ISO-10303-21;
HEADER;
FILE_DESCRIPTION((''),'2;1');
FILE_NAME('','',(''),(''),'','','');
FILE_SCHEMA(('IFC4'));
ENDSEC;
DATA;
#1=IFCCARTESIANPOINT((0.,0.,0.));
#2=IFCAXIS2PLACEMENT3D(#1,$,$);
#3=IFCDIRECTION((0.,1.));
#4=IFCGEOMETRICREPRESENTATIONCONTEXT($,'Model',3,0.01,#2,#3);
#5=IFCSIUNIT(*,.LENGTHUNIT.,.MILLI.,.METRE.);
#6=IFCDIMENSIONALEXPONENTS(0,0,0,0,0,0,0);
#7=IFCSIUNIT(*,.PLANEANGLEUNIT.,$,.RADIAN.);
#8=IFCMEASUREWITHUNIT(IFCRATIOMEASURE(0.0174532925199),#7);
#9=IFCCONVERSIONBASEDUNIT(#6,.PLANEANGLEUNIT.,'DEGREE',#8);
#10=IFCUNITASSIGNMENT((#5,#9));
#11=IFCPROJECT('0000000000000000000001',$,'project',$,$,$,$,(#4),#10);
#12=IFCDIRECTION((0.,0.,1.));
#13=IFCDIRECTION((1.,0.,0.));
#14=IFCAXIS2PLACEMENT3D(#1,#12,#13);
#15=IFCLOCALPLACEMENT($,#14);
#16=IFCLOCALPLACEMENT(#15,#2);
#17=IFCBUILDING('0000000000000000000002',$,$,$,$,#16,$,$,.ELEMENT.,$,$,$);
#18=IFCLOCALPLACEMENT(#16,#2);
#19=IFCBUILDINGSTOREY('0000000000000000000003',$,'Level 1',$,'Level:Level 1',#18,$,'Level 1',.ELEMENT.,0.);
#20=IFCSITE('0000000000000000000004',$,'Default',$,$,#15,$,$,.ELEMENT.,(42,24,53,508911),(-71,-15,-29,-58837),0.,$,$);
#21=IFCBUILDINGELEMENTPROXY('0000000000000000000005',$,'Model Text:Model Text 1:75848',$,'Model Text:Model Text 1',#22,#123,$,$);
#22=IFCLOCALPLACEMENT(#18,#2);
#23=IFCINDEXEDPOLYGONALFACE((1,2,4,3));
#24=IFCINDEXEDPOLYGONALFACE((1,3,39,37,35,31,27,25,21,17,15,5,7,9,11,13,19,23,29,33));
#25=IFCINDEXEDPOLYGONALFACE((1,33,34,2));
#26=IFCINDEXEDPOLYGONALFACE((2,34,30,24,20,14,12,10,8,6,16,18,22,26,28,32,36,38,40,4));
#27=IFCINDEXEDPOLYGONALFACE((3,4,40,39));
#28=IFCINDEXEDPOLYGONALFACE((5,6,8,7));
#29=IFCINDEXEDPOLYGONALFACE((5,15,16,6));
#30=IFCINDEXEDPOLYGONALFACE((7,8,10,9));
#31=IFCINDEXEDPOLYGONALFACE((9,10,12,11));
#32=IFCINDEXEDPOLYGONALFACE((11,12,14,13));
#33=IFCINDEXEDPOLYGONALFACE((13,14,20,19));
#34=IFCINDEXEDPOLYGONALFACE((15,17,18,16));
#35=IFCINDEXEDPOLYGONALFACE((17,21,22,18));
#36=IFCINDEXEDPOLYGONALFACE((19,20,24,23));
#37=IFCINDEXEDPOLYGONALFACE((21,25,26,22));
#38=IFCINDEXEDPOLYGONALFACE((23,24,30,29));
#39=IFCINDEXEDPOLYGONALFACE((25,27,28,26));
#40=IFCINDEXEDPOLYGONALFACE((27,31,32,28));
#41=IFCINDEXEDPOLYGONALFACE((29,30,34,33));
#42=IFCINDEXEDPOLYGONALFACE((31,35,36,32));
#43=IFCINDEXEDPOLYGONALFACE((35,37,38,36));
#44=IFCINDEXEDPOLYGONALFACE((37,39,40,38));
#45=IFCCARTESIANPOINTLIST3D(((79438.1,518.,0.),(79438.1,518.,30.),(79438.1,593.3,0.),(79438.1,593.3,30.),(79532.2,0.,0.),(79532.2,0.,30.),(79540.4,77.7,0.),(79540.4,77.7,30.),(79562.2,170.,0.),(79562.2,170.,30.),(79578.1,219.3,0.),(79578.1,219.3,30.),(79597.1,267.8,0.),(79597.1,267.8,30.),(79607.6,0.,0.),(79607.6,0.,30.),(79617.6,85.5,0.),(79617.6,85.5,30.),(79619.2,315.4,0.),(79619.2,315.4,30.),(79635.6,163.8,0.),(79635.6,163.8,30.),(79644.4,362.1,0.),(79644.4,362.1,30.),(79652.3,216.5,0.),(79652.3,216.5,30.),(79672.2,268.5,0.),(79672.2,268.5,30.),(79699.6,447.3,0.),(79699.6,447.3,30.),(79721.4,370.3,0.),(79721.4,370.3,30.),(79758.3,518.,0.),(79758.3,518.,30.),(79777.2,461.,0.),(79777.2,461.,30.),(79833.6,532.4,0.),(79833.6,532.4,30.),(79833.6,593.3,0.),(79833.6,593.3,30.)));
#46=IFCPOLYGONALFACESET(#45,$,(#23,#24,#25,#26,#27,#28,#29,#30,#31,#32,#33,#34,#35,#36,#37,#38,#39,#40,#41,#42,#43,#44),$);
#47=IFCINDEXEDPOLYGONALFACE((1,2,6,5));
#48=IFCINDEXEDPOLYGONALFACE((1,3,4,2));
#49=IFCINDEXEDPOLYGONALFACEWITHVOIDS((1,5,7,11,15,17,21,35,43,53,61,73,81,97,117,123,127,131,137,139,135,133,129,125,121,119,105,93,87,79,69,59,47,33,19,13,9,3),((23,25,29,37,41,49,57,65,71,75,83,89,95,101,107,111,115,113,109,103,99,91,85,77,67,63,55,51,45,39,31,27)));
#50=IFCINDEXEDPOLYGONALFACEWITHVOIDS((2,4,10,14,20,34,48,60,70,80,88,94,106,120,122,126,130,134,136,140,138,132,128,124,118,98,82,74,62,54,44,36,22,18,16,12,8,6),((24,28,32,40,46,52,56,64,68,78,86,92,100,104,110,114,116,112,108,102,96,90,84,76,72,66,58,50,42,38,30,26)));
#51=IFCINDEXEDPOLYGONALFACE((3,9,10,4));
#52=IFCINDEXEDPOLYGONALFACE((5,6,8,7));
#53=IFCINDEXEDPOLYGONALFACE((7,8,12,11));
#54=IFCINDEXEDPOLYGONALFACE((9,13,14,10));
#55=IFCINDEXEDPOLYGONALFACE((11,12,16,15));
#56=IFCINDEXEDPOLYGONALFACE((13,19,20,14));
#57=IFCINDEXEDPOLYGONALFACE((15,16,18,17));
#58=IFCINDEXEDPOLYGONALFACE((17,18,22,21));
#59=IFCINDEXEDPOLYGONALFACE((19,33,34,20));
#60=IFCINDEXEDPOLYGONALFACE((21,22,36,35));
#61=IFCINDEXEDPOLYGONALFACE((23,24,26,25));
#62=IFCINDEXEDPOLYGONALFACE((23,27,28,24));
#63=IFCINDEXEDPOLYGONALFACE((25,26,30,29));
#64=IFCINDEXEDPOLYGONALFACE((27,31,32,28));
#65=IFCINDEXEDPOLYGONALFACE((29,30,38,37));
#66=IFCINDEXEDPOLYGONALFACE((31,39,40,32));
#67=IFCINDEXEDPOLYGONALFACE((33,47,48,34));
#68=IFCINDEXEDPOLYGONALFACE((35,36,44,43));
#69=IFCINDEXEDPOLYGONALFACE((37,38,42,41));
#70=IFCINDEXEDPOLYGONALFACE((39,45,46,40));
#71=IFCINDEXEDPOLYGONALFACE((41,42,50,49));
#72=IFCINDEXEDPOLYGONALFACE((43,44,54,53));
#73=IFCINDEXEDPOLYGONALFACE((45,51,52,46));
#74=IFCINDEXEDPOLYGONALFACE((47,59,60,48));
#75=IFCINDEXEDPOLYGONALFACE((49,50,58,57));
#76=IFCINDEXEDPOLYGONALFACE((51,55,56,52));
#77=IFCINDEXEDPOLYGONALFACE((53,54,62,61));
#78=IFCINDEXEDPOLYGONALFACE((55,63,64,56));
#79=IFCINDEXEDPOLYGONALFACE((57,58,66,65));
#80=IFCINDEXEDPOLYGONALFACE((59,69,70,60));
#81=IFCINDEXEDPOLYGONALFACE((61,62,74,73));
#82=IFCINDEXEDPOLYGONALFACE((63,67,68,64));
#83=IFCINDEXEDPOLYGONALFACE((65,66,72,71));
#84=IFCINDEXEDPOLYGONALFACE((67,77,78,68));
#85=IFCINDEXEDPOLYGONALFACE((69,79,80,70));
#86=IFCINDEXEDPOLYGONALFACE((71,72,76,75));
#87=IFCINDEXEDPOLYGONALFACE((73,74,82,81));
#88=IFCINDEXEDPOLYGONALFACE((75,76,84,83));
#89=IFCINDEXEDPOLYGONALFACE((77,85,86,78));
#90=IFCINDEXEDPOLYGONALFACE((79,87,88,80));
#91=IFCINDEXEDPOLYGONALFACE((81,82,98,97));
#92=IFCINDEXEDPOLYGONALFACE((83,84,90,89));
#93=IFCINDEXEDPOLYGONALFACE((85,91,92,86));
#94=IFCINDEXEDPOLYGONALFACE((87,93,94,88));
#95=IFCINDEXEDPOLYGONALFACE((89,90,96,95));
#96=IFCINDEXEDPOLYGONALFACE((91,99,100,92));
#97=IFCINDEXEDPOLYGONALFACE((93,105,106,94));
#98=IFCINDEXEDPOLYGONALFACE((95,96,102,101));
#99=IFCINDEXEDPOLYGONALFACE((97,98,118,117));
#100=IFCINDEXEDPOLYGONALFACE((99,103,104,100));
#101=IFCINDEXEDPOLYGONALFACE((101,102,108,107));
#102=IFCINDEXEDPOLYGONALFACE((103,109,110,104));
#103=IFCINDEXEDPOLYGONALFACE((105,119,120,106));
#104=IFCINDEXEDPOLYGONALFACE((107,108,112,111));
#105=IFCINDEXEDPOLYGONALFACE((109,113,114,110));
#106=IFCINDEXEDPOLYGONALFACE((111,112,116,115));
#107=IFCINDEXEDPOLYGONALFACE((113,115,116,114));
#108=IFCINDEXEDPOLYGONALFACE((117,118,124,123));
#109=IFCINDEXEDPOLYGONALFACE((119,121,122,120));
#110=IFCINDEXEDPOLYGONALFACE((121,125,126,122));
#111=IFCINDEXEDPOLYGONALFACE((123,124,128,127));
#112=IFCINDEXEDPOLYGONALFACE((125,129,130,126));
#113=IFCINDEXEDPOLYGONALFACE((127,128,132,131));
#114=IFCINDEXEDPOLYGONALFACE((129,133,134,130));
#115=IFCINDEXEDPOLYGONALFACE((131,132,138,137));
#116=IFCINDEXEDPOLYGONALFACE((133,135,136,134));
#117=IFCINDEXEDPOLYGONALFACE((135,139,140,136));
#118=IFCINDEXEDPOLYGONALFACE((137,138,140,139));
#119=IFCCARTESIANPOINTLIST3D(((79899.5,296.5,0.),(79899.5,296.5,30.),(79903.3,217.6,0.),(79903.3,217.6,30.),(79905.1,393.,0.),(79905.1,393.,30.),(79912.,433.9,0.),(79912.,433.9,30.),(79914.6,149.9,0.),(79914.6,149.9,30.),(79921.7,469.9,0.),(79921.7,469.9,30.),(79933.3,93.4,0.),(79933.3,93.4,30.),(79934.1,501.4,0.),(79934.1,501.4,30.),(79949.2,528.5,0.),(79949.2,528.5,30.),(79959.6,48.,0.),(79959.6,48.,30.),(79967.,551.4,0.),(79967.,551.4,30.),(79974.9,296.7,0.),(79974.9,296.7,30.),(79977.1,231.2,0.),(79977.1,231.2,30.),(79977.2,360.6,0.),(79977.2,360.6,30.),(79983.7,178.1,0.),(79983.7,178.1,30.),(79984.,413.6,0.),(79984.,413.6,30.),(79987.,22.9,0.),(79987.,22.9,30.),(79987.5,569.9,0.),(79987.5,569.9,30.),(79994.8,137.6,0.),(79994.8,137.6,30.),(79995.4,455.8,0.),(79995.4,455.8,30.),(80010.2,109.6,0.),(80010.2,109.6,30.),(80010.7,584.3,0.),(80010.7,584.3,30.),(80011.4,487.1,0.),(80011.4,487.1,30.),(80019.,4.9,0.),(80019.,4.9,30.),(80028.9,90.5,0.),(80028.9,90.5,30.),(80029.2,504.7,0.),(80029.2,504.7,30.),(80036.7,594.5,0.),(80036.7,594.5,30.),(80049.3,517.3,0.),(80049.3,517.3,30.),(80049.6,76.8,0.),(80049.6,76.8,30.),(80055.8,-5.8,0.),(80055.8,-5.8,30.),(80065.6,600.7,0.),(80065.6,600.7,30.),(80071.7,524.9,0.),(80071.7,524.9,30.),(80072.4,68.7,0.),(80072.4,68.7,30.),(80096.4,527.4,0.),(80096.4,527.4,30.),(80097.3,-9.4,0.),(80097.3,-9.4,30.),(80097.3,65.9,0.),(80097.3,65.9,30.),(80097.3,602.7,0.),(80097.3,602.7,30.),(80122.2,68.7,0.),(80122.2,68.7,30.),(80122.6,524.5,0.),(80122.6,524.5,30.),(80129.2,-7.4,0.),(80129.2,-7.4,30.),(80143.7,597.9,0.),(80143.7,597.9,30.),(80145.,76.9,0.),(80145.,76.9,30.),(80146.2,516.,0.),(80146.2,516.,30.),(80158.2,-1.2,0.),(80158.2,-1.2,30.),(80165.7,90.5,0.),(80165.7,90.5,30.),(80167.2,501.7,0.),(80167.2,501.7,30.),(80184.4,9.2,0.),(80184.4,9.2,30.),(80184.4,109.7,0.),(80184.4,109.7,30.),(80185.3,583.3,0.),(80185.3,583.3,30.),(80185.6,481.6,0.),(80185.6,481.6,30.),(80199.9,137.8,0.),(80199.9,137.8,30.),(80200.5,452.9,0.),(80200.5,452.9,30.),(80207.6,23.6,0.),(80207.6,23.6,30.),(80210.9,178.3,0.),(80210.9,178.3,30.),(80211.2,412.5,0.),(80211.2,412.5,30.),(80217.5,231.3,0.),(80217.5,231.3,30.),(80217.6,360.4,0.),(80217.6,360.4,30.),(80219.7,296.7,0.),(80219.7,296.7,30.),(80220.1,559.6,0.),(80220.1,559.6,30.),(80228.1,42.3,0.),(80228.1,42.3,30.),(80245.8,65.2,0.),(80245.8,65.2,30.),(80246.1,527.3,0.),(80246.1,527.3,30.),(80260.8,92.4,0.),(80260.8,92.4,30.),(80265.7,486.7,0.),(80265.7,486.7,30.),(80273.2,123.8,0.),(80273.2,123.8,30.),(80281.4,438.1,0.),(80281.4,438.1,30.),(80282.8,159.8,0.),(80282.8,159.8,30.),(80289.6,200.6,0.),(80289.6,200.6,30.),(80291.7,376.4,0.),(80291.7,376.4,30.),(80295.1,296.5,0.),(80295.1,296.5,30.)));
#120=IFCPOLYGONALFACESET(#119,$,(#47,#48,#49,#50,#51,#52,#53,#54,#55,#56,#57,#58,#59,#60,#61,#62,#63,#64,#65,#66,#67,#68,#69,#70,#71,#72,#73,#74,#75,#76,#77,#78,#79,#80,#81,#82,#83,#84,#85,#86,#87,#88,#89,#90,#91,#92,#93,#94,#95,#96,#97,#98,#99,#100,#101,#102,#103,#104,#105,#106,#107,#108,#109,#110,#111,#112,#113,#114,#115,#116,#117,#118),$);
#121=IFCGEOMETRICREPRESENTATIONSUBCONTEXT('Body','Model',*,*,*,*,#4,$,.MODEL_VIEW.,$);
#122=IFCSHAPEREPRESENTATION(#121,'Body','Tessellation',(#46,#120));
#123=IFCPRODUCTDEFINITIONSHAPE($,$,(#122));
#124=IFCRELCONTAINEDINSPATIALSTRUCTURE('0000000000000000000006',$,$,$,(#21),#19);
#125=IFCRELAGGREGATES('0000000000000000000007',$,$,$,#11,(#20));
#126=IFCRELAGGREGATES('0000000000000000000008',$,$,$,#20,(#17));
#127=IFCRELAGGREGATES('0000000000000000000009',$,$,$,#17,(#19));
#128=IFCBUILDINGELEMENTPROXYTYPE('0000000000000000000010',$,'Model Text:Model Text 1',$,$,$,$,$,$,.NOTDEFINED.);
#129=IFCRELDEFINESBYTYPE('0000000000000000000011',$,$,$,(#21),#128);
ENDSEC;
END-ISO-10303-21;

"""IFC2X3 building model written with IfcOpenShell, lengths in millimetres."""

from ifc_helpers import new_model, entity, si_unit, converted_unit, direction, frame, origin, origin_with_axes, place, context, subcontext, project, spatial, polyline, outline, extrude, type_object, element, save


model = new_model("IFC2X3")

# Units and contexts
model_context = context("Model", 3, precision=0.01, world=origin(), true_north=direction((0.0, 1.0)))
body_context = subcontext(model_context, "Body", "Model", "MODEL_VIEW")
ifc_project = project(units=[si_unit("LENGTHUNIT", "METRE", prefix="MILLI"), converted_unit("PLANEANGLEUNIT", "DEGREE", entity("IfcRatioMeasure", 0.0174532925199), si_unit("PLANEANGLEUNIT", "RADIAN"), dimensions=[0, 0, 0, 0, 0, 0, 0])], contexts=[model_context])

# Site, building, storey
site_placement = place(None, origin_with_axes())
site = spatial("IfcSite", under=ifc_project, at=site_placement, Name="Default", CompositionType="ELEMENT", RefLatitude=(42, 24, 53, 508911), RefLongitude=(-71, -15, -29, -58837), RefElevation=0.0)
building_placement = place(site_placement, origin())
building = spatial("IfcBuilding", under=site, at=building_placement, CompositionType="ELEMENT")
storey_placement = place(building_placement, origin())
storey = spatial("IfcBuildingStorey", under=building, at=storey_placement, Name="Level 1", ObjectType="Level:Level 1", LongName="Level 1", CompositionType="ELEMENT", Elevation=0.0)

# Building element proxy
building_element_proxy_type_1 = type_object("IfcBuildingElementProxyType", Name="Model Text:Model Text 1", PredefinedType="NOTDEFINED")
proxy_1_placement = place(storey_placement, frame((79438.1, -9.4, 0.0)))
element("IfcBuildingElementProxy", 1, at=proxy_1_placement, inside=storey, type_object=building_element_proxy_type_1, Name="Model Text:Model Text 1:75848", ObjectType="Model Text:Model Text 1", context=body_context, shape_type="SweptSolid", body=[
    extrude(outline(polyline([(-199.9, -209.0), (-199.9, -284.3), (195.7, -284.3), (195.7, -223.4), (139.3, -152.0), (83.5, -61.3), (34.2, 40.5), (14.4, 92.5), (-2.4, 145.2), (-20.3, 223.5), (-30.3, 309.0), (-105.7, 309.0), (-97.5, 231.3), (-75.7, 139.0), (-59.9, 89.7), (-40.9, 41.2), (-18.8, -6.4), (6.4, -53.1), (61.7, -138.3), (120.3, -209.0), (-199.9, -209.0)])), frame((199.9, 318.4, 0.0), z_axis=(0.0, 0.0, -1.0), x_axis=(1.0, 0.0, 0.0)), (0.0, 0.0, -1.0), 30.0),
    extrude(outline(polyline([(-10.6, -198.7), (68.3, -198.7), (136.5, -190.7), (193.9, -174.7), (240.5, -150.6), (266.9, -124.4), (286.3, -93.2), (298.8, -57.0), (304.3, -15.7), (303.8, 16.2), (299.0, 45.5), (289.9, 72.1), (276.6, 96.0), (258.9, 117.3), (236.9, 136.2), (210.4, 152.5), (179.6, 166.3), (144.1, 177.6), (103.7, 186.3), (8.2, 196.4), (-71.8, 196.7), (-134.0, 189.4), (-183.3, 176.1), (-224.7, 158.4), (-258.2, 133.9), (-283.5, 100.3), (-300.1, 59.5), (-307.1, 13.4), (-306.6, -18.4), (-301.8, -47.5), (-292.8, -74.0), (-279.6, -97.9), (-262.0, -119.2), (-240.0, -138.1), (-213.6, -154.5), (-182.8, -168.4), (-147.3, -179.8), (-106.7, -188.6), (-10.6, -198.7)]), holes=[polyline([(-7.2, -123.5), (-71.0, -118.2), (-123.6, -108.8), (-165.2, -95.4), (-195.7, -78.0), (-212.4, -59.4), (-224.1, -38.7), (-230.6, -15.9), (-231.9, 8.9), (-227.8, 35.0), (-218.1, 58.1), (-202.8, 78.4), (-182.0, 95.8), (-152.6, 109.4), (-111.7, 118.1), (-59.4, 122.0), (4.4, 121.1), (69.6, 115.8), (122.2, 106.7), (162.2, 93.7), (189.5, 77.0), (207.7, 57.4), (220.4, 36.0), (227.5, 12.8), (229.1, -12.1), (225.2, -36.8), (215.9, -59.2), (201.3, -79.3), (181.4, -97.1), (152.6, -111.2), (111.6, -120.3), (58.3, -124.4), (-7.2, -123.5)])]), frame((660.5, 304.7, 0.0), z_axis=(0.0, 0.0, 1.0), x_axis=(0.047515, -0.998871, 0.0)), (0.0, 0.0, 1.0), 30.0),
])

save(model, "model.ifc")
